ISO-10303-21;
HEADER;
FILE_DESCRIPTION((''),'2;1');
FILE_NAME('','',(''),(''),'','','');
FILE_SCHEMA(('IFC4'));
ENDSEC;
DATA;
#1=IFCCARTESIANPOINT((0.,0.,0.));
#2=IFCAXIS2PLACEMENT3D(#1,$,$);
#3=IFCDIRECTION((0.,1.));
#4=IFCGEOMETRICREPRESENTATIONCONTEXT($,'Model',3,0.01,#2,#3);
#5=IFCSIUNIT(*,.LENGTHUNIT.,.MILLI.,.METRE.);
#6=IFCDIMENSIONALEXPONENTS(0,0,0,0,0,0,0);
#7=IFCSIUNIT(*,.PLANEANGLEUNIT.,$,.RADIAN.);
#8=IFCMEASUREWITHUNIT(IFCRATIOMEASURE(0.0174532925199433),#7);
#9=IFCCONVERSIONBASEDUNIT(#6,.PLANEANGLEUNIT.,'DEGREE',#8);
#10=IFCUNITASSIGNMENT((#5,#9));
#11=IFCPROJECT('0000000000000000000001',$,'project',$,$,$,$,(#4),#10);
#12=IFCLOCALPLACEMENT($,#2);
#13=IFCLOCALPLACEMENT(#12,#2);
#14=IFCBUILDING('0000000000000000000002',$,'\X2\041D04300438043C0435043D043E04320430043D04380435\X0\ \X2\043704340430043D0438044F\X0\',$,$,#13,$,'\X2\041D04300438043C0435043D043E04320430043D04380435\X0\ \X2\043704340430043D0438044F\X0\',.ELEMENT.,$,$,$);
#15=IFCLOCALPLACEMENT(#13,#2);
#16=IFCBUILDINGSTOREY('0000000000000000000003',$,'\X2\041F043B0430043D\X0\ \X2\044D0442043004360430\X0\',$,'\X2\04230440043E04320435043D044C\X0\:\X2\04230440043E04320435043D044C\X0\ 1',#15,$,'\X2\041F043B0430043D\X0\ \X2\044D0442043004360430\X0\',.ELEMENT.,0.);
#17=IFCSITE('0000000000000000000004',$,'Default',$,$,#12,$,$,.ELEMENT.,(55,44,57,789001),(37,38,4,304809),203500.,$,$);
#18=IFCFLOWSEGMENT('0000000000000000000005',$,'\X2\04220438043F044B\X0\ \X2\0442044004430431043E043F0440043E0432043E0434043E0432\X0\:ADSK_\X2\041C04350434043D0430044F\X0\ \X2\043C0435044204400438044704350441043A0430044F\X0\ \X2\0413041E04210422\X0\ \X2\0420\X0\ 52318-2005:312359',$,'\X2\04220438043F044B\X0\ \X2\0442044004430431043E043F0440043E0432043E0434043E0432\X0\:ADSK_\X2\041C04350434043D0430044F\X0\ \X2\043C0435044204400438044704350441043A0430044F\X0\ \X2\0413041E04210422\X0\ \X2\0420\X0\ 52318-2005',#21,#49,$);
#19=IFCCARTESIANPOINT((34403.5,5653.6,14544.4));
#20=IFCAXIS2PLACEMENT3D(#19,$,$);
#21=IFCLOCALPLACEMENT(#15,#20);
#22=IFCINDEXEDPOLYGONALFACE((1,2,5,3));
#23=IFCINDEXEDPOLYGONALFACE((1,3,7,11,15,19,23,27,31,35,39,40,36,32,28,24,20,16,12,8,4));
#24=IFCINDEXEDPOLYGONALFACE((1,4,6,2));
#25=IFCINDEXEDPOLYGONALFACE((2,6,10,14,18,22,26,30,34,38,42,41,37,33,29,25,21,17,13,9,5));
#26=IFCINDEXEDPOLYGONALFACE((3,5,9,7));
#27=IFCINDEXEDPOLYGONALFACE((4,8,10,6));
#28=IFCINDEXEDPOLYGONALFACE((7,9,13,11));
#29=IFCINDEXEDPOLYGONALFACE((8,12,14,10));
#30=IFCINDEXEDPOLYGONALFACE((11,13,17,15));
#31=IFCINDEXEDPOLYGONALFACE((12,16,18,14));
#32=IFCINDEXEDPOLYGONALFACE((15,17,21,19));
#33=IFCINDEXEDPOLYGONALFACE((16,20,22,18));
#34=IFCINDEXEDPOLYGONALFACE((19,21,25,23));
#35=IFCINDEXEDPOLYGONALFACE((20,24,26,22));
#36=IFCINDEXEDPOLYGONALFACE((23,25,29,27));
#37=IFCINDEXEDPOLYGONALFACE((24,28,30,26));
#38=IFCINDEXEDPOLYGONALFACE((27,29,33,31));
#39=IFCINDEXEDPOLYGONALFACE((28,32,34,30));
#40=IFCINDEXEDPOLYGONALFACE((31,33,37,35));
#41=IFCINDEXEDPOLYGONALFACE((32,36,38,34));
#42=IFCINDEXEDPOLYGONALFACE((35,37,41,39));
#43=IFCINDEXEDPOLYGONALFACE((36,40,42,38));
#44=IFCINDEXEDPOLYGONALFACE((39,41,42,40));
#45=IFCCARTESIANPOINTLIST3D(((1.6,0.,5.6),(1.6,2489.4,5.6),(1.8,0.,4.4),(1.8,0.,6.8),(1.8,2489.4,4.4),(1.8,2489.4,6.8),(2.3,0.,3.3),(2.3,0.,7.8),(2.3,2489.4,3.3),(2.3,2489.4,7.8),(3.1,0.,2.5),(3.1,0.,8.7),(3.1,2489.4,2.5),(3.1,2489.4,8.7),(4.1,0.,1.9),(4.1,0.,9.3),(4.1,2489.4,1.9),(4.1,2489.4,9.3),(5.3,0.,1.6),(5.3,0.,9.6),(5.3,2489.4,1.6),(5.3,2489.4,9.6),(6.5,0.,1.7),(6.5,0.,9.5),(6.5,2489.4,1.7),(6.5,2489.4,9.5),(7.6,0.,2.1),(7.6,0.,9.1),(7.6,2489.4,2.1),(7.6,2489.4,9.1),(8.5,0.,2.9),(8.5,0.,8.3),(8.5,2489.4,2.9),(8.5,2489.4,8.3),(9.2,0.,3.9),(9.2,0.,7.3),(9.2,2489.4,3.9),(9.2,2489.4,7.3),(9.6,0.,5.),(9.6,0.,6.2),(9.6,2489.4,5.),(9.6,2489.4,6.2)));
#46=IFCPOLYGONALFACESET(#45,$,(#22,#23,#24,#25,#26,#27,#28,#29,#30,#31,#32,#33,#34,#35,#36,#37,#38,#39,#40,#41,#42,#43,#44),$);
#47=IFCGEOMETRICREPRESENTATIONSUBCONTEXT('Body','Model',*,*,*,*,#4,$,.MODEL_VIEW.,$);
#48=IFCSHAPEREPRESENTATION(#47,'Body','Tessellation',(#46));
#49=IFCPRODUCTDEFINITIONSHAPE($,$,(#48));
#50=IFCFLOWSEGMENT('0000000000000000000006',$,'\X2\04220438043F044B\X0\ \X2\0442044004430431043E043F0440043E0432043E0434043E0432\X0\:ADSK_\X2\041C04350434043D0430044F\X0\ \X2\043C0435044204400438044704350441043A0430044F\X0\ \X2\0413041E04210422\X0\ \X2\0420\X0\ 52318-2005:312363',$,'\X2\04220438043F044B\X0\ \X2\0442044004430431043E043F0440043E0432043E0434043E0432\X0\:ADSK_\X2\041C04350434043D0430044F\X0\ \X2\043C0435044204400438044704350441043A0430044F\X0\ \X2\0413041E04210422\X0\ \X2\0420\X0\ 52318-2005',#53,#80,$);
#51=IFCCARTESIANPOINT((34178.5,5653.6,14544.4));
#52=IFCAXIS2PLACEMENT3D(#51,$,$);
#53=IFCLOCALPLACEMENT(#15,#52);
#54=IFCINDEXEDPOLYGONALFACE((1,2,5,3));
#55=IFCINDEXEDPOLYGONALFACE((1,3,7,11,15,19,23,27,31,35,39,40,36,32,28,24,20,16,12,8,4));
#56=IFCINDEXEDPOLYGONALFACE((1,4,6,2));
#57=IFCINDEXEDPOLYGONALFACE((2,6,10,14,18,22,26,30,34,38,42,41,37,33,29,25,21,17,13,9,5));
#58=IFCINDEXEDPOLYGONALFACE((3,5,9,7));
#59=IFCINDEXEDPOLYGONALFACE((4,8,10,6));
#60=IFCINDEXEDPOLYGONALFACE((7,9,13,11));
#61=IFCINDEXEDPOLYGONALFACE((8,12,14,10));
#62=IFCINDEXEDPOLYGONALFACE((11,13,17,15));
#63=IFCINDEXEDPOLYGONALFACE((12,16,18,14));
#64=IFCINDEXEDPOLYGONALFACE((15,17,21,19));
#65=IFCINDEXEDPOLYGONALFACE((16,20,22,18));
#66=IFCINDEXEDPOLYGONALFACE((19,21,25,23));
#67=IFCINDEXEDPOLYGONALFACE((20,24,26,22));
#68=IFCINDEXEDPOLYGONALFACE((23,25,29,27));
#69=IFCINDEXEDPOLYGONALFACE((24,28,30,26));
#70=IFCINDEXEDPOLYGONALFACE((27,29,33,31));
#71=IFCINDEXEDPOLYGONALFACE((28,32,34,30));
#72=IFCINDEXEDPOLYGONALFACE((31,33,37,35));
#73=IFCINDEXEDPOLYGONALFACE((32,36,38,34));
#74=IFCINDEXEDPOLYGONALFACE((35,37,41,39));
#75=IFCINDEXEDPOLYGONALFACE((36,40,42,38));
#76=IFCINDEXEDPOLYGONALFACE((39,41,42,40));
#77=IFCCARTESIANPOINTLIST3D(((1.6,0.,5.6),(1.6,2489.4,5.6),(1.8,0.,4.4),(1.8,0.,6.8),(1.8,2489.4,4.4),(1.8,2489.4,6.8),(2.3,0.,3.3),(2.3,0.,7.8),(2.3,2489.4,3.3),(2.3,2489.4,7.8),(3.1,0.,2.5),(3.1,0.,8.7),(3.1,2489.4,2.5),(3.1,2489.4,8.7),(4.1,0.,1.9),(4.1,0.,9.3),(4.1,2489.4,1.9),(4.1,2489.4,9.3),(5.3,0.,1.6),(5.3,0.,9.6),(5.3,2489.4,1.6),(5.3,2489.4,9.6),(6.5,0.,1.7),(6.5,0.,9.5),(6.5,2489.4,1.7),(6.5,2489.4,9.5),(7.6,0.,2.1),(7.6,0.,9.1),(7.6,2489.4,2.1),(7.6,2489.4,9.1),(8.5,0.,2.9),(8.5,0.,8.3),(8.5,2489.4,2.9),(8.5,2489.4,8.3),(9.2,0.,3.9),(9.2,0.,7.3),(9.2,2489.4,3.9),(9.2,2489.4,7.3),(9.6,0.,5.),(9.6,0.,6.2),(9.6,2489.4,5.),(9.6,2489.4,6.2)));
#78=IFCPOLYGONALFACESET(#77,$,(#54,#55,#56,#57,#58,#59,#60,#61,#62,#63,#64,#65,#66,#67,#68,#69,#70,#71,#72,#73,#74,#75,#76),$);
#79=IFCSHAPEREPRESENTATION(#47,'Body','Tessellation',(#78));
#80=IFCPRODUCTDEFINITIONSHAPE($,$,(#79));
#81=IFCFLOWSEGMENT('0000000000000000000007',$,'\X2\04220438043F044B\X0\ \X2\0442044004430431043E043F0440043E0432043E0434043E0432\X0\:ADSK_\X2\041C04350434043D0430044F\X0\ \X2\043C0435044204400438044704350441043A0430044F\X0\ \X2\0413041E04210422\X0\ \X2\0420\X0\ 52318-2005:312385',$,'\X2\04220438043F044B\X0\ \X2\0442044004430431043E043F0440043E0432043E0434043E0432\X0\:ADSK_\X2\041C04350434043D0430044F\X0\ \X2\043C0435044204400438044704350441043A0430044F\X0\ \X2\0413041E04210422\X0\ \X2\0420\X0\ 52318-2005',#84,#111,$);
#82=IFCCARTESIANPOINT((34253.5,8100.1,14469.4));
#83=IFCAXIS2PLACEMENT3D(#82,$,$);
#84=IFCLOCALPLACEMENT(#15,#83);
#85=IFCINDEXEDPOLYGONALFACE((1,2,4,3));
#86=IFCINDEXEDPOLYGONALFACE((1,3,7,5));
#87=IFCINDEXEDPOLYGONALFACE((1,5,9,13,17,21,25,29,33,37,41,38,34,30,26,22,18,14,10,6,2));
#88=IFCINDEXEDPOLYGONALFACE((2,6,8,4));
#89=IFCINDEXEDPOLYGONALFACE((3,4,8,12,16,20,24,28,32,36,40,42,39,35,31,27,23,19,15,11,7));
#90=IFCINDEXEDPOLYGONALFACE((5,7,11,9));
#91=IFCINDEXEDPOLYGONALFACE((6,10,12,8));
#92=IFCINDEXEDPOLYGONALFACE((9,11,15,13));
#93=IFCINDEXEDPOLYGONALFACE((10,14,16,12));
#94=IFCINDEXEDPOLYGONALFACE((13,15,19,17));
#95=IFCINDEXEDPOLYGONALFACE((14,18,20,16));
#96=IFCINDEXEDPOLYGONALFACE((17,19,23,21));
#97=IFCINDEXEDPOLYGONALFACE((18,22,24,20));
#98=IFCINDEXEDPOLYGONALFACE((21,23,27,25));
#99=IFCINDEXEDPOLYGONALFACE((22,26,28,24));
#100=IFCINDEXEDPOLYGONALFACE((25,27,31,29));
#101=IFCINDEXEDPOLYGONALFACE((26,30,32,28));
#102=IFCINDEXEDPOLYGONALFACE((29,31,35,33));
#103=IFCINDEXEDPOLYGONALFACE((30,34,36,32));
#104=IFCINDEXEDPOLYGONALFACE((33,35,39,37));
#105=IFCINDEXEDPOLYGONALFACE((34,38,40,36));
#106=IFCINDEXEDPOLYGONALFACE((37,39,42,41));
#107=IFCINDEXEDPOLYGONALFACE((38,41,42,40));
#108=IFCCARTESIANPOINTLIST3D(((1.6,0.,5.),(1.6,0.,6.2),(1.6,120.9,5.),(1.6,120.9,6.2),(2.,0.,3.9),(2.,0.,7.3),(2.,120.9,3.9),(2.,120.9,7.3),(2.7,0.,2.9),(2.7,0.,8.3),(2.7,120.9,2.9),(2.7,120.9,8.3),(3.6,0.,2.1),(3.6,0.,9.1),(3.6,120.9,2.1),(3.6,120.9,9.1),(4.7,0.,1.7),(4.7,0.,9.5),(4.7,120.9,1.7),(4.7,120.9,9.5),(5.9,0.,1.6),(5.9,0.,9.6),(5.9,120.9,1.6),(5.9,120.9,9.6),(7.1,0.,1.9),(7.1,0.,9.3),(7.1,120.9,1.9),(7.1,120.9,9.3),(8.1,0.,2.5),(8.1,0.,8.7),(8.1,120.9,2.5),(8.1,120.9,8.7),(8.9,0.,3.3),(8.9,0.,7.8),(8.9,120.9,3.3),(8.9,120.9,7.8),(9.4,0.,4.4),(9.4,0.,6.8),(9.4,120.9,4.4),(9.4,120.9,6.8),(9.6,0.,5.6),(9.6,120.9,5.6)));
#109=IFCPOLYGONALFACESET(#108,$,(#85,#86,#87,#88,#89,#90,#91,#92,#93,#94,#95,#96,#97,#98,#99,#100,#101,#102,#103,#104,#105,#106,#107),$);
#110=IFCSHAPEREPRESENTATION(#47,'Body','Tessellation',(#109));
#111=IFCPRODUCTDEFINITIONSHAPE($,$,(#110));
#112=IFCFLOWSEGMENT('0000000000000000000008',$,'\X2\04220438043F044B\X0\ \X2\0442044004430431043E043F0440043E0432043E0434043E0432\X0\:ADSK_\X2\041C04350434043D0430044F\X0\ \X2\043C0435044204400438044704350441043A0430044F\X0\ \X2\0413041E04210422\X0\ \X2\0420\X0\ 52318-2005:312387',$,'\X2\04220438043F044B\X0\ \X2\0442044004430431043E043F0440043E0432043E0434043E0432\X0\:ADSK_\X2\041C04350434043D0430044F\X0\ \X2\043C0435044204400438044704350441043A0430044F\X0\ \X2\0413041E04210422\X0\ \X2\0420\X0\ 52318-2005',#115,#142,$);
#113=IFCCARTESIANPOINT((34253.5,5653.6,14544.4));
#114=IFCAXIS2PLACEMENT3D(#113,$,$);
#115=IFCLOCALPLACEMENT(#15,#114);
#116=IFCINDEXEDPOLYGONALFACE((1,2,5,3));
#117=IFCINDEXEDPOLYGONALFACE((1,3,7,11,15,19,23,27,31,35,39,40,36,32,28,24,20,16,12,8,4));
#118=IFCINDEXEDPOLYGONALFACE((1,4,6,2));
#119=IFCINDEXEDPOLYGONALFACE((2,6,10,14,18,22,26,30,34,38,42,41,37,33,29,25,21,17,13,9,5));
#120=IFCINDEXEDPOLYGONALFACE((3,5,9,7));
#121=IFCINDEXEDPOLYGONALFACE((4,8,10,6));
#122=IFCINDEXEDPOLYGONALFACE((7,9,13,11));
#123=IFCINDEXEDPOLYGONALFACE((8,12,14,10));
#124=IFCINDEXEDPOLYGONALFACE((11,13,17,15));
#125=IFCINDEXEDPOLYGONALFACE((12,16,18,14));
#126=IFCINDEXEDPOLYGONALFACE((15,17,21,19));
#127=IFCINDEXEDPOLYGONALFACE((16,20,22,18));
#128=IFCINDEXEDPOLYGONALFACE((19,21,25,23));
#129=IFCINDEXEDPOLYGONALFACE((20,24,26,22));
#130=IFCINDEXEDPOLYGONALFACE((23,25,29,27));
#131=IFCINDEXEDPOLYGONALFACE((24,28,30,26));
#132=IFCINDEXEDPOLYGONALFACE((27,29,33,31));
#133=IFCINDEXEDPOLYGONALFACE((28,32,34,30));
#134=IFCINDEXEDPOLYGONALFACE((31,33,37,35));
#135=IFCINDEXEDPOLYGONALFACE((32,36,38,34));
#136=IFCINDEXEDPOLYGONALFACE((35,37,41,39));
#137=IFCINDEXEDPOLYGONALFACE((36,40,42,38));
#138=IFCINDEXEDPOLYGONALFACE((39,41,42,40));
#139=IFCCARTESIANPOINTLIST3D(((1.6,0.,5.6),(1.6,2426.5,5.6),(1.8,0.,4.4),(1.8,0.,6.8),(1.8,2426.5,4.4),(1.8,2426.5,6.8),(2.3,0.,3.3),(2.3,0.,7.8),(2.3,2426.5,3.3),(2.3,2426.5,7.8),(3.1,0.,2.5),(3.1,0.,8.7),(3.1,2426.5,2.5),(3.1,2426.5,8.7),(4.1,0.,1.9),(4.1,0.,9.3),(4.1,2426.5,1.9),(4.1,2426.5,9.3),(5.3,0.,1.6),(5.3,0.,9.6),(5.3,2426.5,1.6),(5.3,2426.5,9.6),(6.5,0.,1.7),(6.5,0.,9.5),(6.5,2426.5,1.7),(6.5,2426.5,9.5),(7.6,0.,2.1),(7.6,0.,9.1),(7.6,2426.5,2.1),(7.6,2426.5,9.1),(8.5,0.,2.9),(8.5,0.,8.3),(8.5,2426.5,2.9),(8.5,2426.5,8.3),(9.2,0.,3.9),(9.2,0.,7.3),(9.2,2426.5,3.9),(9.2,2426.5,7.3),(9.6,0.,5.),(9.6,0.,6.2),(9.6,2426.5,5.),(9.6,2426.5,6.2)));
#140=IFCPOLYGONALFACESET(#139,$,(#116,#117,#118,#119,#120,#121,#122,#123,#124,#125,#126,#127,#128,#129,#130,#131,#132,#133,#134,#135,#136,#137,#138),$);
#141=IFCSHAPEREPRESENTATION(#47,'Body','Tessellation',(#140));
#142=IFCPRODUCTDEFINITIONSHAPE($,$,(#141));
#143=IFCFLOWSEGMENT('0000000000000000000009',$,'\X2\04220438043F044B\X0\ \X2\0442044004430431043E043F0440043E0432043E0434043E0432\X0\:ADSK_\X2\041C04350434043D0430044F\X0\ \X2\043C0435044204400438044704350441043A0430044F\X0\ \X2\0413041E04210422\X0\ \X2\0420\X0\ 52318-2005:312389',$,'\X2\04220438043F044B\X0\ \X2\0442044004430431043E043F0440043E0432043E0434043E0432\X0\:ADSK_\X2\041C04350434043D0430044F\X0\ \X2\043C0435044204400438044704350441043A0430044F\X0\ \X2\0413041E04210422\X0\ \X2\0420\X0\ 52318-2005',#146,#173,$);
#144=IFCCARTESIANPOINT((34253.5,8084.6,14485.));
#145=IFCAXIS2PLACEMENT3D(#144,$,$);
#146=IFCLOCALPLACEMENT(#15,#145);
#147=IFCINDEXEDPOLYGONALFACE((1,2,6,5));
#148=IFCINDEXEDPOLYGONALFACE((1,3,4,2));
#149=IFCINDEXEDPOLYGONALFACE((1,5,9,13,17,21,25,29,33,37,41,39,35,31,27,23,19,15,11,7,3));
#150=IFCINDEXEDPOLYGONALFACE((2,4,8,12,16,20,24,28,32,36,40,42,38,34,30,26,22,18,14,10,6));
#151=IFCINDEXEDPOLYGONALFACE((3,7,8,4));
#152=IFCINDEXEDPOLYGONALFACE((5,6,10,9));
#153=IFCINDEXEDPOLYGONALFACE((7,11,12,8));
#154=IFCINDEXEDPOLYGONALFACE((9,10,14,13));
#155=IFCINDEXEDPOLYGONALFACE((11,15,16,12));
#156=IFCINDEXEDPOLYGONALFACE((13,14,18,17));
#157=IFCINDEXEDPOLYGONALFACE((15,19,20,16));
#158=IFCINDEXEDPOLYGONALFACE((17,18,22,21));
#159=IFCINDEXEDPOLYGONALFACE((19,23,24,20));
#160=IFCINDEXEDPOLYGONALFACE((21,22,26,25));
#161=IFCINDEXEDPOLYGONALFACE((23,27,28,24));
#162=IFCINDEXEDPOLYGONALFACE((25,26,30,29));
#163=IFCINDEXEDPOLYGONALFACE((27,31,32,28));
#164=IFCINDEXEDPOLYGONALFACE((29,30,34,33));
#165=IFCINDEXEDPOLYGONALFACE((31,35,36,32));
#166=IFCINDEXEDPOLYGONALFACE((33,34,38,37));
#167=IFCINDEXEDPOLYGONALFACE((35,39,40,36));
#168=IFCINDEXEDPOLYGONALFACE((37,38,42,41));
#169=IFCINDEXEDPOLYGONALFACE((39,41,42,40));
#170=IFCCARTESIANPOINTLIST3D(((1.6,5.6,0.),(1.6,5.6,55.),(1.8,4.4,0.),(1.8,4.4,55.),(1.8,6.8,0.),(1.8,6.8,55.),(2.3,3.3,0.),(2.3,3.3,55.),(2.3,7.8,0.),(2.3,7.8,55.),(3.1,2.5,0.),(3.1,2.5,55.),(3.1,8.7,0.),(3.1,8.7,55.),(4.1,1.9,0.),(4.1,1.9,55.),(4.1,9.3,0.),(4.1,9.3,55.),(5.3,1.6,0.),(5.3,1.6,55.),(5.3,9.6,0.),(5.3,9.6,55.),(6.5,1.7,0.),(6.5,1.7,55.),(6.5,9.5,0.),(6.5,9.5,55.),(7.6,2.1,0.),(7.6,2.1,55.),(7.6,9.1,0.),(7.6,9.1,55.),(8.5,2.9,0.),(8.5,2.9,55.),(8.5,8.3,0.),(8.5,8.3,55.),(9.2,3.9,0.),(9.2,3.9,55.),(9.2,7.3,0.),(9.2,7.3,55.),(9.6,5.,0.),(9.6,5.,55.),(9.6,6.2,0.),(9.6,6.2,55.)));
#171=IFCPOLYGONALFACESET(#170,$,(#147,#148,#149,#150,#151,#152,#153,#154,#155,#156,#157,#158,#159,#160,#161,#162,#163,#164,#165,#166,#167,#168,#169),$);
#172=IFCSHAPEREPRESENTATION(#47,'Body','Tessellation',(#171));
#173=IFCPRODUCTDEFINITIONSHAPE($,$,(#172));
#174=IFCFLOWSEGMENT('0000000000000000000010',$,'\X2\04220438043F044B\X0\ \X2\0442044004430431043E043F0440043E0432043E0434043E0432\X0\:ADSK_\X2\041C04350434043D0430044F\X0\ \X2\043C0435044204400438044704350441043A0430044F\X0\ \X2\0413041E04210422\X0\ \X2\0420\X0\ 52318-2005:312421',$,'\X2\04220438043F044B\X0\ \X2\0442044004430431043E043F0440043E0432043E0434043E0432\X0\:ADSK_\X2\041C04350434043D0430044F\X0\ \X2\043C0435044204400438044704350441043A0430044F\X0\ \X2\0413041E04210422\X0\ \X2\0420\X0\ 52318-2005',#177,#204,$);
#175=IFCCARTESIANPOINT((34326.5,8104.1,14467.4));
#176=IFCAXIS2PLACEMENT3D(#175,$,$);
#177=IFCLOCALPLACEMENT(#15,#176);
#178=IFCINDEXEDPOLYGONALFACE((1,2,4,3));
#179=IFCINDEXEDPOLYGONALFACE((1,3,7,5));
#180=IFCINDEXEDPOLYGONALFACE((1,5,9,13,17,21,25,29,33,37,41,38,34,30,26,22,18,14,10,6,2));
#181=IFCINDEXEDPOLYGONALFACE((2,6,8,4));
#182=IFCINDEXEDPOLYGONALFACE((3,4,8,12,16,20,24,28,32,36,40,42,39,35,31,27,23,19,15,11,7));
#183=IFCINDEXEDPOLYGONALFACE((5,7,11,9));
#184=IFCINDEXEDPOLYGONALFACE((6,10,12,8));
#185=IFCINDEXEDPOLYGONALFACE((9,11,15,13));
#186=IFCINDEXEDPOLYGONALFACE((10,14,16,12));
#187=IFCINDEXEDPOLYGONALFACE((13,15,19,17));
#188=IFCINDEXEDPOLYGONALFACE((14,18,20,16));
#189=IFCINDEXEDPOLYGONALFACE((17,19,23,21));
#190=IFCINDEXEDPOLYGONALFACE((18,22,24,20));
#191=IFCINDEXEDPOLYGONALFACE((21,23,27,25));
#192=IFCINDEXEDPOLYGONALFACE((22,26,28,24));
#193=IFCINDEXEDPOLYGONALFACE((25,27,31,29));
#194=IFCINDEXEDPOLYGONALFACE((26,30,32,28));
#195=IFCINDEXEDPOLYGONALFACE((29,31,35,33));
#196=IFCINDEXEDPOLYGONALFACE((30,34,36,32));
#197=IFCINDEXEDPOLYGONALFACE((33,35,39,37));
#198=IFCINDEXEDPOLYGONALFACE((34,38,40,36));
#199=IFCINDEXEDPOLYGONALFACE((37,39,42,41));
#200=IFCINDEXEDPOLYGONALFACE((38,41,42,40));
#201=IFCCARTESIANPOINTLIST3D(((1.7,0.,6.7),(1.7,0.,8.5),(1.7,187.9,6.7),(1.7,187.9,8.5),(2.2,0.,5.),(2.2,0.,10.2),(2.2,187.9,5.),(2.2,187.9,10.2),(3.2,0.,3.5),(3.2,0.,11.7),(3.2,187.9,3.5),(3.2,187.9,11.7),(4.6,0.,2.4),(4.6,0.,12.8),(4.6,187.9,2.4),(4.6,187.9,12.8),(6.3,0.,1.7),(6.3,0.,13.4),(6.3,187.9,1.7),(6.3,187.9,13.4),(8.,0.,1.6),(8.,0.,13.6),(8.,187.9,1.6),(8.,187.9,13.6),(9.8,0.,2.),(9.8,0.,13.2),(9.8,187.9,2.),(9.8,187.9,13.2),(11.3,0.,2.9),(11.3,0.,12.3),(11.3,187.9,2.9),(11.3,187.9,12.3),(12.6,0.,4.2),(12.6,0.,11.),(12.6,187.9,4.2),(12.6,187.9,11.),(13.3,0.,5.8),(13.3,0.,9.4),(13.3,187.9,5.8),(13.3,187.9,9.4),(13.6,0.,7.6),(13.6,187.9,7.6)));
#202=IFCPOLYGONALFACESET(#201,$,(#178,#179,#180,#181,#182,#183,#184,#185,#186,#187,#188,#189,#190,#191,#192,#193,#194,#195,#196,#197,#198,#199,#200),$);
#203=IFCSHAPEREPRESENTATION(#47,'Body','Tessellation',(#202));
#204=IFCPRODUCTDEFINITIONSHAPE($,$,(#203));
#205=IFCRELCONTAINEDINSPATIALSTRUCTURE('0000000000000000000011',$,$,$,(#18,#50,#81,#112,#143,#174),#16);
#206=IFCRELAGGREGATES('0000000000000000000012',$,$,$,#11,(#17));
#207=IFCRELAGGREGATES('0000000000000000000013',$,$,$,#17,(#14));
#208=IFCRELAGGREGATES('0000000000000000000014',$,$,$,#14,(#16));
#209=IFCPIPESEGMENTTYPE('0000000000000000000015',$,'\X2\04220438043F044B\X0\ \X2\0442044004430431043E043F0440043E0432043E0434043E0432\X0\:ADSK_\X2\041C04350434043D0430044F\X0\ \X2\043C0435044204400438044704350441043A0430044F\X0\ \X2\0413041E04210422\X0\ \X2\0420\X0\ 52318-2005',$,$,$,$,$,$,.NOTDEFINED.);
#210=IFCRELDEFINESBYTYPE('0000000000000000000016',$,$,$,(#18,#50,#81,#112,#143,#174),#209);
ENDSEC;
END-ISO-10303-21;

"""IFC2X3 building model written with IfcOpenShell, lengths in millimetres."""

from ifc_helpers import new_model, entity, si_unit, converted_unit, direction, frame, frame_2d, origin, origin_2d_with_axis, place, context, subcontext, project, spatial, circle, extrude, type_object, element, save


model = new_model("IFC2X3")

# Units and contexts
model_context = context("Model", 3, precision=0.01, world=origin(), true_north=direction((0.0, 1.0)))
body_context = subcontext(model_context, "Body", "Model", "MODEL_VIEW")
ifc_project = project(units=[si_unit("LENGTHUNIT", "METRE", prefix="MILLI"), converted_unit("PLANEANGLEUNIT", "DEGREE", entity("IfcRatioMeasure", 0.0174532925199433), si_unit("PLANEANGLEUNIT", "RADIAN"), dimensions=[0, 0, 0, 0, 0, 0, 0])], contexts=[model_context])

# Site, building, storey
site_placement = place(None, frame((0.0, 0.0, 0.0)))
site = spatial("IfcSite", under=ifc_project, at=site_placement, Name="Default", CompositionType="ELEMENT", RefLatitude=(55, 44, 57, 789001), RefLongitude=(37, 38, 4, 304809), RefElevation=203500.0)
building_placement = place(site_placement, origin())
building = spatial("IfcBuilding", under=site, at=building_placement, Name="Наименование здания", LongName="Наименование здания", CompositionType="ELEMENT")
storey_placement = place(building_placement, origin())
storey = spatial("IfcBuildingStorey", under=building, at=storey_placement, Name="План этажа", ObjectType="Уровень:Уровень 1", LongName="План этажа", CompositionType="ELEMENT", Elevation=0.0)

# Flow segments
pipe_segment_type = type_object("IfcPipeSegmentType", Name="Типы трубопроводов:ADSK_Медная метрическая ГОСТ Р 52318-2005", PredefinedType="NOTDEFINED")
flow_segment_1_placement = place(storey_placement, frame((34403.5, 5653.6, 14544.4)))
element("IfcFlowSegment", 1, at=flow_segment_1_placement, inside=storey, type_object=pipe_segment_type, Name="Типы трубопроводов:ADSK_Медная метрическая ГОСТ Р 52318-2005:312359", ObjectType="Типы трубопроводов:ADSK_Медная метрическая ГОСТ Р 52318-2005", context=body_context, shape_type="SweptSolid", body=[
    extrude(circle(Radius=4.0, at=frame_2d((0.0, 0.0), x_axis=(1.0, 0.0))), frame((5.6, 0.0, 5.6), z_axis=(0.0, 1.0, 0.0), x_axis=(-1.0, 0.0, 0.0)), (0.0, 0.0, 1.0), 2489.4),
])
flow_segment_2_placement = place(storey_placement, frame((34178.5, 5653.6, 14544.4)))
element("IfcFlowSegment", 2, at=flow_segment_2_placement, inside=storey, type_object=pipe_segment_type, Name="Типы трубопроводов:ADSK_Медная метрическая ГОСТ Р 52318-2005:312363", ObjectType="Типы трубопроводов:ADSK_Медная метрическая ГОСТ Р 52318-2005", context=body_context, shape_type="SweptSolid", body=[
    extrude(circle(Radius=4.0, at=frame_2d((0.0, 0.0), x_axis=(1.0, 0.0))), frame((5.6, 0.0, 5.6), z_axis=(0.0, 1.0, 0.0), x_axis=(-1.0, 0.0, 0.0)), (0.0, 0.0, 1.0), 2489.4),
])
flow_segment_3_placement = place(storey_placement, frame((34253.5, 8100.1, 14469.4)))
element("IfcFlowSegment", 3, at=flow_segment_3_placement, inside=storey, type_object=pipe_segment_type, Name="Типы трубопроводов:ADSK_Медная метрическая ГОСТ Р 52318-2005:312385", ObjectType="Типы трубопроводов:ADSK_Медная метрическая ГОСТ Р 52318-2005", context=body_context, shape_type="SweptSolid", body=[
    extrude(circle(Radius=4.0, at=origin_2d_with_axis()), frame((5.6, 0.0, 5.6), z_axis=(0.0, 1.0, 0.0), x_axis=(1.0, 0.0, 0.0)), (0.0, 0.0, 1.0), 120.9),
])
flow_segment_4_placement = place(storey_placement, frame((34253.5, 5653.6, 14544.4)))
element("IfcFlowSegment", 4, at=flow_segment_4_placement, inside=storey, type_object=pipe_segment_type, Name="Типы трубопроводов:ADSK_Медная метрическая ГОСТ Р 52318-2005:312387", ObjectType="Типы трубопроводов:ADSK_Медная метрическая ГОСТ Р 52318-2005", context=body_context, shape_type="SweptSolid", body=[
    extrude(circle(Radius=4.0, at=origin_2d_with_axis()), frame((5.6, 0.0, 5.6), z_axis=(0.0, 1.0, 0.0), x_axis=(-1.0, 0.0, 0.0)), (0.0, 0.0, 1.0), 2426.5),
])
flow_segment_5_placement = place(storey_placement, frame((34253.5, 8084.6, 14485.0)))
element("IfcFlowSegment", 5, at=flow_segment_5_placement, inside=storey, type_object=pipe_segment_type, Name="Типы трубопроводов:ADSK_Медная метрическая ГОСТ Р 52318-2005:312389", ObjectType="Типы трубопроводов:ADSK_Медная метрическая ГОСТ Р 52318-2005", context=body_context, shape_type="SweptSolid", body=[
    extrude(circle(Radius=4.0, at=frame_2d((0.0, 0.0), x_axis=(1.0, 0.0))), frame((5.6, 5.6, 0.0), z_axis=(0.0, 0.0, 1.0), x_axis=(-1.0, 0.0, 0.0)), (0.0, 0.0, 1.0), 55.0),
])
flow_segment_6_placement = place(storey_placement, frame((34326.5, 8104.1, 14467.4)))
element("IfcFlowSegment", 6, at=flow_segment_6_placement, inside=storey, type_object=pipe_segment_type, Name="Типы трубопроводов:ADSK_Медная метрическая ГОСТ Р 52318-2005:312421", ObjectType="Типы трубопроводов:ADSK_Медная метрическая ГОСТ Р 52318-2005", context=body_context, shape_type="SweptSolid", body=[
    extrude(circle(Radius=6.0, at=origin_2d_with_axis()), frame((7.6, 0.0, 7.6), z_axis=(0.0, 1.0, 0.0), x_axis=(1.0, 0.0, 0.0)), (0.0, 0.0, 1.0), 187.9),
])

save(model, "model.ifc")
